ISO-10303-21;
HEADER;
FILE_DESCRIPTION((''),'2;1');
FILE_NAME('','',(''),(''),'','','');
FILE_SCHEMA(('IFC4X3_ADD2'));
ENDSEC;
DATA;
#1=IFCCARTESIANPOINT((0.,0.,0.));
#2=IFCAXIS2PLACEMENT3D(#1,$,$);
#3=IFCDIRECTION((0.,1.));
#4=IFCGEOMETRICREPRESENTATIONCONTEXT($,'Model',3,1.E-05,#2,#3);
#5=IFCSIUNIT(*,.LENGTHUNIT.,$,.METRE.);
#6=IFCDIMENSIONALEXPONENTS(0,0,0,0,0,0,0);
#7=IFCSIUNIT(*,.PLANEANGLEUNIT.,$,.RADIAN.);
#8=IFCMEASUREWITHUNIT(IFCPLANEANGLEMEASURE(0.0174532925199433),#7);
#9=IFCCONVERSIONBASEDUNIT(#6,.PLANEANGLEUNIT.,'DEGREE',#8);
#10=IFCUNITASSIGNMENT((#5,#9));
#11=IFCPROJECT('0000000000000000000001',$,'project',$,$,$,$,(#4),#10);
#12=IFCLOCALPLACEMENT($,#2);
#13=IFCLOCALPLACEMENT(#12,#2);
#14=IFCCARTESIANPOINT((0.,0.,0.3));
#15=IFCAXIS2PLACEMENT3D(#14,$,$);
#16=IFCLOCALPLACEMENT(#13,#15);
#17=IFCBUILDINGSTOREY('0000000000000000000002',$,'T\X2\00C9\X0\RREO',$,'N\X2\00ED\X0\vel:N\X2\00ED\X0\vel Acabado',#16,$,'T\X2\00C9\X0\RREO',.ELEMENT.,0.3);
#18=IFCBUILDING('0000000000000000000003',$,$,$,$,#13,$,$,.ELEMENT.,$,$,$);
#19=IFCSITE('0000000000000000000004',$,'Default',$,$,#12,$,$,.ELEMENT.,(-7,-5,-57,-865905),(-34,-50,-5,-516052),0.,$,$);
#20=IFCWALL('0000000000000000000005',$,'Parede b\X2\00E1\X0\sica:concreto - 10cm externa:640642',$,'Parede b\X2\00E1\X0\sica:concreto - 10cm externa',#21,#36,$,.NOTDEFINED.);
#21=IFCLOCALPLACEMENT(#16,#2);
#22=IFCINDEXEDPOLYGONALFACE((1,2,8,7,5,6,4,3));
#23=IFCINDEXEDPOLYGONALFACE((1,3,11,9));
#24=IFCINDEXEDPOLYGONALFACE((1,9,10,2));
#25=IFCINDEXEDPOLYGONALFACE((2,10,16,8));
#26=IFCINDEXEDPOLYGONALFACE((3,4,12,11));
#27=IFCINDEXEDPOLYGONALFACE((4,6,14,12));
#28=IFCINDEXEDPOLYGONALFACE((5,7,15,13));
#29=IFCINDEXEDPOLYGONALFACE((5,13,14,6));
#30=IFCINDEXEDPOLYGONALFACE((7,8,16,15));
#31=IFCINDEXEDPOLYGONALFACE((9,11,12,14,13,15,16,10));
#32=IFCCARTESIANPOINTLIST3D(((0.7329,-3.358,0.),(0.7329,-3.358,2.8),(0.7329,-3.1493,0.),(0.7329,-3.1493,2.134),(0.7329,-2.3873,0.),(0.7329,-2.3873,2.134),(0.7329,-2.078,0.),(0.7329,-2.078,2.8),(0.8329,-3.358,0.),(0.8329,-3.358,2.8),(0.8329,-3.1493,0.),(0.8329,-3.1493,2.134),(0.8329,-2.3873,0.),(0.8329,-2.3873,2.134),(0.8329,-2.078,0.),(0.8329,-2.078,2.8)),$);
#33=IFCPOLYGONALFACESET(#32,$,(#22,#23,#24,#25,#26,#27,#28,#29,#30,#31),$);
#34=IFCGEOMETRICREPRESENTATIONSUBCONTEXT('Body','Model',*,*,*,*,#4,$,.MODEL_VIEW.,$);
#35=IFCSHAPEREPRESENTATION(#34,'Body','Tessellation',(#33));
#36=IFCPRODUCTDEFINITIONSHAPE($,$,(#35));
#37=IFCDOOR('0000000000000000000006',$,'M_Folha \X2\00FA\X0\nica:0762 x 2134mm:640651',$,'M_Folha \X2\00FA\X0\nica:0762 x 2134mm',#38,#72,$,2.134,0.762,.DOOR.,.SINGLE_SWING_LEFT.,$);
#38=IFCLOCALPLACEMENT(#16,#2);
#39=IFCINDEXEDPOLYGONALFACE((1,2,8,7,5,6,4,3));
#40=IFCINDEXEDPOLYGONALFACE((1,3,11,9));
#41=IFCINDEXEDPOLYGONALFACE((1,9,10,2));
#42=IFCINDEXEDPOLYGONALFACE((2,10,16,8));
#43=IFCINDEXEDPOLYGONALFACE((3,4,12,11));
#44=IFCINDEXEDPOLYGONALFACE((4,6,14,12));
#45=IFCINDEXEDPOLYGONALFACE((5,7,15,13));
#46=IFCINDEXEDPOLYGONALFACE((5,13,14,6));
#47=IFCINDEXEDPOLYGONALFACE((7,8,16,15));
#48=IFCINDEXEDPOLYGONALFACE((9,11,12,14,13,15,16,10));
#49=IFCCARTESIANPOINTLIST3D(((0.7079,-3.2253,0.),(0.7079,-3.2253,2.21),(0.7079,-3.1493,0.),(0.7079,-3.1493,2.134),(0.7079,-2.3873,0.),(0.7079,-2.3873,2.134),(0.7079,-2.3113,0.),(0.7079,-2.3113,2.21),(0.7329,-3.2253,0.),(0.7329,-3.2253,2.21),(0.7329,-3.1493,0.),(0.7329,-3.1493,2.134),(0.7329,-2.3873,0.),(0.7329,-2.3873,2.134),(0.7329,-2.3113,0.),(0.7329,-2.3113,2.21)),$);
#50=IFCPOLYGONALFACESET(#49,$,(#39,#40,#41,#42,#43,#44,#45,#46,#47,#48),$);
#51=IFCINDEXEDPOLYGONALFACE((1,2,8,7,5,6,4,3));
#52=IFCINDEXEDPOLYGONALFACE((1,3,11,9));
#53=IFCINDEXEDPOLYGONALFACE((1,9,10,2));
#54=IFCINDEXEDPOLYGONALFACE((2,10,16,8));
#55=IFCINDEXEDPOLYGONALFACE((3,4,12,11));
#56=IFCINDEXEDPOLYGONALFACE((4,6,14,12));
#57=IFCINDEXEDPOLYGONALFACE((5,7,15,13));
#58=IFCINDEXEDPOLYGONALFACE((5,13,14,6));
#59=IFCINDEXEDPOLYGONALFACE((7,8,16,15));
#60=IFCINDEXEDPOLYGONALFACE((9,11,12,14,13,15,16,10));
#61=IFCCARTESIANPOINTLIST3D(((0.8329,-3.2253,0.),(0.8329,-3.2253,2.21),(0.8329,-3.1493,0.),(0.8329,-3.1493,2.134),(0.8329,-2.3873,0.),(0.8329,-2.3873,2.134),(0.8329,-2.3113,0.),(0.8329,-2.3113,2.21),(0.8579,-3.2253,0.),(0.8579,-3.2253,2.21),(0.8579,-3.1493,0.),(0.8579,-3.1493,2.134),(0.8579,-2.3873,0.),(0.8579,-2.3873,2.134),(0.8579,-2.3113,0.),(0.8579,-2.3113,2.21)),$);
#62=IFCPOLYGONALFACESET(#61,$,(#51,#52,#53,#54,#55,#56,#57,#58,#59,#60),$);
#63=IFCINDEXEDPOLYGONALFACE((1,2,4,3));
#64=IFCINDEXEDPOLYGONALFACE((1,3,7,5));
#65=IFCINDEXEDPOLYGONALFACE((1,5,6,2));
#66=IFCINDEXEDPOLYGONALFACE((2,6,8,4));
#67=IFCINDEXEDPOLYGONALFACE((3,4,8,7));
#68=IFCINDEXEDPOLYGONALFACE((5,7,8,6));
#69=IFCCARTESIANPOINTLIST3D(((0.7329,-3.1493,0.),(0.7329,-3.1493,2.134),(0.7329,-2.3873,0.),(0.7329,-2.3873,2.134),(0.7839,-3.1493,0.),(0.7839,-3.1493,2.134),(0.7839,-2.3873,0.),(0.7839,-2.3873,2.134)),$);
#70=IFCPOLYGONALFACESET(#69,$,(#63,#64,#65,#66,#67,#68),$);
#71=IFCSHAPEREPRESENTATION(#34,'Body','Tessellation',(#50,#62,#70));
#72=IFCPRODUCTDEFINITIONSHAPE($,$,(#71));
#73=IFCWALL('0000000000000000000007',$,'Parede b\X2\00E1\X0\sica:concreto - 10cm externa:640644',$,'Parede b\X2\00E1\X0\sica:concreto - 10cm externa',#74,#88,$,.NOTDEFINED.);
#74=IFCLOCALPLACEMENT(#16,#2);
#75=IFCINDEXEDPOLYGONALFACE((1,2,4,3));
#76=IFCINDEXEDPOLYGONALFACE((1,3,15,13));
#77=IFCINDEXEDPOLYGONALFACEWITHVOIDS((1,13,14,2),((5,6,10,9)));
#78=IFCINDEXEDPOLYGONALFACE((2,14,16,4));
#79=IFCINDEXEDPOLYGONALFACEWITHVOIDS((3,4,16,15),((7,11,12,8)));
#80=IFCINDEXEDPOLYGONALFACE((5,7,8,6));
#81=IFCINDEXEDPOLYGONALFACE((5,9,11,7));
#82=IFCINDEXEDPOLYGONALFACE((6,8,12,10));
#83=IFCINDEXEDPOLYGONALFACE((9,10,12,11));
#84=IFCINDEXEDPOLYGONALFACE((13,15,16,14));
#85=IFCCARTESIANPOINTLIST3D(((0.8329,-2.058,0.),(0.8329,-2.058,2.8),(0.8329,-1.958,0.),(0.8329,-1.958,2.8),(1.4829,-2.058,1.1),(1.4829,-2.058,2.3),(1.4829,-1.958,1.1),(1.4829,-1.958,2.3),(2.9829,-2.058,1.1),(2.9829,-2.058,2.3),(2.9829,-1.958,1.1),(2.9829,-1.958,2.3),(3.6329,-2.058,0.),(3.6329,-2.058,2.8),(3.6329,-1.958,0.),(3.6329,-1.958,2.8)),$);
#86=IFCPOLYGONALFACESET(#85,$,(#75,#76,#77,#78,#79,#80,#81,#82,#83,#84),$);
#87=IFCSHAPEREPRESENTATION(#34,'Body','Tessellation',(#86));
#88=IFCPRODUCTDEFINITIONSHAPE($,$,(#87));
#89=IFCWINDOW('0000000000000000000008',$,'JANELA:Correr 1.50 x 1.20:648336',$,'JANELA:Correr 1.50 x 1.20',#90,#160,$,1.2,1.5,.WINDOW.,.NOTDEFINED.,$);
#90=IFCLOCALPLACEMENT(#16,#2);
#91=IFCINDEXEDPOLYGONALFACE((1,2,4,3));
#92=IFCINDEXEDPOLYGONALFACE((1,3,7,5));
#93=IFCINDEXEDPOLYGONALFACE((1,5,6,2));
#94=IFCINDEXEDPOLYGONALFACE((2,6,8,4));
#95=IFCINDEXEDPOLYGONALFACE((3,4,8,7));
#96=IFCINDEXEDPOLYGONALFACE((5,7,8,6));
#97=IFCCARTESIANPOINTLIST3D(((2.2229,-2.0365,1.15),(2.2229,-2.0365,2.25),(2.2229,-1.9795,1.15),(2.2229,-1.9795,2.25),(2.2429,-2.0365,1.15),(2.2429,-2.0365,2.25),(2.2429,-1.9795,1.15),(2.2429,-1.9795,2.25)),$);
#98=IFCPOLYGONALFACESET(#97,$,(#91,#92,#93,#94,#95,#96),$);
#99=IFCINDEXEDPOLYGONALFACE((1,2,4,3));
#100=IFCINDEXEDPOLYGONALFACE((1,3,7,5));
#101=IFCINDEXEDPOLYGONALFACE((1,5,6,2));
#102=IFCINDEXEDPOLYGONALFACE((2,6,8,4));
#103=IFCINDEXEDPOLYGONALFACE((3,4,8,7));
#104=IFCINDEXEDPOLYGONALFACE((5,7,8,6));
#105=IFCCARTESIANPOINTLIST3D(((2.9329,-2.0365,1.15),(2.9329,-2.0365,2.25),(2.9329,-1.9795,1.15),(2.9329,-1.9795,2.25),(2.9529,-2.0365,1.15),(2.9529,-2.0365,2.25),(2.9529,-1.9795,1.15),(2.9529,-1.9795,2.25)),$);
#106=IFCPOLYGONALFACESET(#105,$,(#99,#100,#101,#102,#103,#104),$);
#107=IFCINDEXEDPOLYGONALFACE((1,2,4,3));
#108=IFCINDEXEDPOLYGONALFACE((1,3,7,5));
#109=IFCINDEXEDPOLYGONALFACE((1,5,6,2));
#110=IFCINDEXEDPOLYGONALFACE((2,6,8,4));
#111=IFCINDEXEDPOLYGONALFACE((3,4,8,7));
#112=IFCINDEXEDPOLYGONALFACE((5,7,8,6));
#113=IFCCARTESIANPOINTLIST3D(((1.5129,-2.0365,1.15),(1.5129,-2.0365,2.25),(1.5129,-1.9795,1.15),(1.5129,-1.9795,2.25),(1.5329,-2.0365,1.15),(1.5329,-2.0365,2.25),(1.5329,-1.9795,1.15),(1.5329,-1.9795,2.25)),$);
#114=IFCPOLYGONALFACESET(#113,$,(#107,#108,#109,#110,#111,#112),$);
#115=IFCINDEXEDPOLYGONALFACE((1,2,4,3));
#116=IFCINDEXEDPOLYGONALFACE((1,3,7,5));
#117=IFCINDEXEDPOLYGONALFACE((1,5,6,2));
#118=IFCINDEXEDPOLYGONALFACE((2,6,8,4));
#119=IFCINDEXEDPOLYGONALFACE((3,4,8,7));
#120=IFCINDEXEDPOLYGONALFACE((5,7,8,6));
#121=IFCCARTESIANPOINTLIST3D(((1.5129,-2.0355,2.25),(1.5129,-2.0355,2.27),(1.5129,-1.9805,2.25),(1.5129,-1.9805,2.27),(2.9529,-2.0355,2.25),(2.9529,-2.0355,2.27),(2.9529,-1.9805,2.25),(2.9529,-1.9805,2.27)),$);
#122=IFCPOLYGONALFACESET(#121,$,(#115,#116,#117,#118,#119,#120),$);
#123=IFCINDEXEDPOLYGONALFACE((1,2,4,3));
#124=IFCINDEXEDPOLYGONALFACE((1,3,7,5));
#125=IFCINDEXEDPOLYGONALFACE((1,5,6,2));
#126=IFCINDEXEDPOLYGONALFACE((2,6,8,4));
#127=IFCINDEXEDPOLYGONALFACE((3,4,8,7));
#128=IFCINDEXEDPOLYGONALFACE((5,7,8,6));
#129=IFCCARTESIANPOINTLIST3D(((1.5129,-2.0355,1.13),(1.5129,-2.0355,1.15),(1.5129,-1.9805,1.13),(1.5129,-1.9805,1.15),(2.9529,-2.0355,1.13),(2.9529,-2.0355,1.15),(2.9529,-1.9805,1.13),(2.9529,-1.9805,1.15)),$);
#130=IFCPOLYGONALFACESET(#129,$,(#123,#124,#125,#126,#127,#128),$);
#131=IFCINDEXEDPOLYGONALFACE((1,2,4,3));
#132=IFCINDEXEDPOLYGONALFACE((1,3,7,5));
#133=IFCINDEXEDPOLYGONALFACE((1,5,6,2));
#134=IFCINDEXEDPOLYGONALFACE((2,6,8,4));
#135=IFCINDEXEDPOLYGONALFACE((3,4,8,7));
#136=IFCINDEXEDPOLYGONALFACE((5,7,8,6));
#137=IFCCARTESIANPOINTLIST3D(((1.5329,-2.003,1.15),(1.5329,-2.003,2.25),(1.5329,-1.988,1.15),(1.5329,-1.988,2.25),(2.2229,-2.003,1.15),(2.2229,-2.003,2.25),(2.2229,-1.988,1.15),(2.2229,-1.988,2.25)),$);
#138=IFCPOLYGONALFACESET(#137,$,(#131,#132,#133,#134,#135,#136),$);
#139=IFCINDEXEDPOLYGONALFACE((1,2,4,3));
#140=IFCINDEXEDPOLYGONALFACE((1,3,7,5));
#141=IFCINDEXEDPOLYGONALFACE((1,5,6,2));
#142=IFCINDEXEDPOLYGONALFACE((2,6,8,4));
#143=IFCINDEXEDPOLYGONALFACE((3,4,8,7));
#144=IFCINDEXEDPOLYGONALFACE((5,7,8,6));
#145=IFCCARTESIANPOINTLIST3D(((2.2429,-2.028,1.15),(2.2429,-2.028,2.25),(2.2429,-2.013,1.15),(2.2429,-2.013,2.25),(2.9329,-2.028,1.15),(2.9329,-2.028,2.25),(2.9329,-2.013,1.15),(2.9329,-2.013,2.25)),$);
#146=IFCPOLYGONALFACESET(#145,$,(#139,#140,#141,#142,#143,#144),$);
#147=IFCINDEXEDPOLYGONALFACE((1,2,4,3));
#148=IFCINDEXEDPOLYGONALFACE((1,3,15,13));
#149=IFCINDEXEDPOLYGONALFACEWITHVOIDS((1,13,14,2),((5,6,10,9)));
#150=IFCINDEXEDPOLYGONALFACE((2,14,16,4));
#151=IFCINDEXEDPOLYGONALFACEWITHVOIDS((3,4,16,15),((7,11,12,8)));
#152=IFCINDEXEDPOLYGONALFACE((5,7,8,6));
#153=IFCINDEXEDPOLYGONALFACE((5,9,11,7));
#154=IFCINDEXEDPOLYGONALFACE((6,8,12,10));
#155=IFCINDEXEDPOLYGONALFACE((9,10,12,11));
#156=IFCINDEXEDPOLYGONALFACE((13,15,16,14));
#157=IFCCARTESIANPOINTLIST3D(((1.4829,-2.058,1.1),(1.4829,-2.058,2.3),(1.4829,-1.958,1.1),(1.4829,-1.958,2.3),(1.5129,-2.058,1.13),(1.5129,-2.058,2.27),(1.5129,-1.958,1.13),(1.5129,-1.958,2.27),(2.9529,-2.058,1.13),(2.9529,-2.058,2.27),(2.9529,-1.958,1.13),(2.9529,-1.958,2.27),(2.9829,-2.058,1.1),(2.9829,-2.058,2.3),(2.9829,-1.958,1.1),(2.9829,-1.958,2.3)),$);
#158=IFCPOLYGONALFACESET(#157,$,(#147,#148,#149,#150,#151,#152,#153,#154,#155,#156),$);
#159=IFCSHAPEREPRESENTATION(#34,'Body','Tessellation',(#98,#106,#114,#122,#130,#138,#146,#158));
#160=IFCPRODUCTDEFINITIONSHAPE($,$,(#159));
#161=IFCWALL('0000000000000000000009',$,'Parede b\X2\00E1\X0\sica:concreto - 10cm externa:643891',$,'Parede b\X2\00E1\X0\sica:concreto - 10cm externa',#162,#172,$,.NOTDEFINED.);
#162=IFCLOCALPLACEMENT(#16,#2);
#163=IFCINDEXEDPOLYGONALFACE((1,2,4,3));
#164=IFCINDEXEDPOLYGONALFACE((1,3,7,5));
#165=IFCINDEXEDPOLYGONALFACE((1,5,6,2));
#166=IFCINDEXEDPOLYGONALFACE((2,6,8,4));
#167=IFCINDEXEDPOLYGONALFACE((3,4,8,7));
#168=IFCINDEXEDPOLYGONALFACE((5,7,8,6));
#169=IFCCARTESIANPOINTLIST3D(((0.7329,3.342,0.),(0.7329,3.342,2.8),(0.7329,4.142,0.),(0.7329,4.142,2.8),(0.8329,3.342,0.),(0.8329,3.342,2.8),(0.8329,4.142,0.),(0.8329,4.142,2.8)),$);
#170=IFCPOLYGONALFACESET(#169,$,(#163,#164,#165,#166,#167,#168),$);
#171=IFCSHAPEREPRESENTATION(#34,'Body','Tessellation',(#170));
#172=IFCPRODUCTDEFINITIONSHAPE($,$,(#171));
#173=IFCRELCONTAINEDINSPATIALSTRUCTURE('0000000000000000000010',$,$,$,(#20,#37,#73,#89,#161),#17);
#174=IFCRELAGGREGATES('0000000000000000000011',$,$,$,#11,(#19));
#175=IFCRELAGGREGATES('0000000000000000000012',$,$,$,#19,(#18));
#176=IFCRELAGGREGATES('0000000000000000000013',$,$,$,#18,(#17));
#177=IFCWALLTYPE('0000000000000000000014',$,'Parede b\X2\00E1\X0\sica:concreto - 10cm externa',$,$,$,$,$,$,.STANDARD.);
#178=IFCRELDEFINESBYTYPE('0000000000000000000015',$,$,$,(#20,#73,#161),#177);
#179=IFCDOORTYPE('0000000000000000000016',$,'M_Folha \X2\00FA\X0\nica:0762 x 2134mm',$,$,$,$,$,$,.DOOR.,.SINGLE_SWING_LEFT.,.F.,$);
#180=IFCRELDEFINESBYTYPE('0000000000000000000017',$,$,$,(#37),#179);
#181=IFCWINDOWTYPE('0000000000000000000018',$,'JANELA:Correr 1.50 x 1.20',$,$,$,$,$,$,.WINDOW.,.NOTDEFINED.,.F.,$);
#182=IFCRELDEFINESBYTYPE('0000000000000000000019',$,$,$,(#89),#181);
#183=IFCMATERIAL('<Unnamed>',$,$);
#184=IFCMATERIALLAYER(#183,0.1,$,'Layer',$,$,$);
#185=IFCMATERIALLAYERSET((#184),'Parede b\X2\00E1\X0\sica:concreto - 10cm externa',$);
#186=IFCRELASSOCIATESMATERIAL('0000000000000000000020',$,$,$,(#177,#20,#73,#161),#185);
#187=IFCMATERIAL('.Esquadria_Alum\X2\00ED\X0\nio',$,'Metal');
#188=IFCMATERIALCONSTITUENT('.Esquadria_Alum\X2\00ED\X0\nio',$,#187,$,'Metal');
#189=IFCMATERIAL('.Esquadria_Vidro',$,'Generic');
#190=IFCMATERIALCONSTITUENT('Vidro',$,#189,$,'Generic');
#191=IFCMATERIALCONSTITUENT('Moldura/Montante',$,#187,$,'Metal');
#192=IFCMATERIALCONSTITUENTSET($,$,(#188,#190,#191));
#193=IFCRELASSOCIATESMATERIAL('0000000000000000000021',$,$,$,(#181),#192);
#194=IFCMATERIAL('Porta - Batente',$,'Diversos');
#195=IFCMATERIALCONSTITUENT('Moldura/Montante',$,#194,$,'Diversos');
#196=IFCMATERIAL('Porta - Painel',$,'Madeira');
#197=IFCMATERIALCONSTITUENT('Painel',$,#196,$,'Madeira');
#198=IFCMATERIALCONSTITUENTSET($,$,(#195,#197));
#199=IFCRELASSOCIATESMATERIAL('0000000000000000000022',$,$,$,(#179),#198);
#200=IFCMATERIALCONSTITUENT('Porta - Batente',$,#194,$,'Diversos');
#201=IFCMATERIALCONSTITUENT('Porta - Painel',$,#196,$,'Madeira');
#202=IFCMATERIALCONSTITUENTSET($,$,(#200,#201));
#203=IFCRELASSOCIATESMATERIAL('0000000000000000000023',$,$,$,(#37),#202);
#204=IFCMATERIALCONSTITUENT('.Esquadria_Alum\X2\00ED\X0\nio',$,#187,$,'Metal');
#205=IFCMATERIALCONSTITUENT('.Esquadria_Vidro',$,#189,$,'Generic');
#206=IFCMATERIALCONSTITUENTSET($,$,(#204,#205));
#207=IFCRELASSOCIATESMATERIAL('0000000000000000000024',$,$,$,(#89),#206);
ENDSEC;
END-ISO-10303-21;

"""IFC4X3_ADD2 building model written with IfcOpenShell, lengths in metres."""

from ifc_helpers import new_model, entity, si_unit, converted_unit, direction, frame, frame_2d, origin, origin_2d_with_axis, place, context, subcontext, project, spatial, polyline, rectangle, outline, extrude, source, transform, mapped, material, layer, layer_set, constituent, constituent_set, type_object, type_shapes, element, fill, save


model = new_model("IFC4X3_ADD2")

# Units and contexts
model_context = context("Model", 3, precision=1e-05, world=origin(), true_north=direction((0.0, 1.0)))
body_context = subcontext(model_context, "Body", "Model", "MODEL_VIEW")
ifc_project = project(units=[si_unit("LENGTHUNIT", "METRE"), converted_unit("PLANEANGLEUNIT", "DEGREE", entity("IfcPlaneAngleMeasure", 0.0174532925199433), si_unit("PLANEANGLEUNIT", "RADIAN"), dimensions=[0, 0, 0, 0, 0, 0, 0])], contexts=[model_context])

# Site, building, storey
site_placement = place(None, origin())
site = spatial("IfcSite", under=ifc_project, at=site_placement, Name="Default", CompositionType="ELEMENT", RefLatitude=(-7, -5, -57, -865905), RefLongitude=(-34, -50, -5, -516052), RefElevation=0.0)
building_placement = place(site_placement, origin())
building = spatial("IfcBuilding", under=site, at=building_placement, CompositionType="ELEMENT")
storey_placement = place(building_placement, frame((0.0, 0.0, 0.3)))
storey = spatial("IfcBuildingStorey", under=building, at=storey_placement, Name="TÉRREO", ObjectType="Nível:Nível Acabado", LongName="TÉRREO", CompositionType="ELEMENT", Elevation=0.3)

# Shared definitions
ifc_material_1 = material(Name="<Unnamed>")
ifc_layer_1 = layer(ifc_material_1, 0.1, Name="Layer")
ifc_layer_set_1 = layer_set([ifc_layer_1], Name="Parede básica:concreto - 10cm externa")
wall_type_1 = type_object("IfcWallType", Name="Parede básica:concreto - 10cm externa", PredefinedType="STANDARD", material=ifc_layer_set_1)
ifc_material_2 = material(Name=".Esquadria_Alumínio", Category="Metal")
ifc_material_3 = material(Name=".Esquadria_Vidro", Category="Generic")
ifc_constituent_1 = constituent(ifc_material_2, Name=".Esquadria_Alumínio", Category="Metal")
ifc_constituent_2 = constituent(ifc_material_3, Name="Vidro", Category="Generic")
ifc_constituent_3 = constituent(ifc_material_2, Name="Moldura/Montante", Category="Metal")
ifc_constituent_set_1 = constituent_set(constituents=[ifc_constituent_1, ifc_constituent_2, ifc_constituent_3])
window_type_1 = type_object("IfcWindowType", Name="JANELA:Correr 1.50 x 1.20", ParameterTakesPrecedence=False, PartitioningType="NOTDEFINED", PredefinedType="WINDOW", material=ifc_constituent_set_1)
shared_shape_1 = source(origin(), body_context, "Body", "SweptSolid", [
    extrude(rectangle(XDim=0.02, YDim=0.057, at=origin_2d_with_axis()), frame((0.75, 0.05, 0.05), z_axis=(0.0, 0.0, 1.0), x_axis=(-1.0, 0.0, 0.0)), (0.0, 0.0, 1.0), 1.1),
    extrude(rectangle(XDim=0.02, YDim=0.057, at=origin_2d_with_axis()), frame((0.04, 0.05, 0.05), z_axis=(0.0, 0.0, 1.0), x_axis=(-1.0, 0.0, 0.0)), (0.0, 0.0, 1.0), 1.1),
    extrude(rectangle(XDim=0.02, YDim=0.057, at=origin_2d_with_axis()), frame((1.46, 0.05, 0.05), z_axis=(0.0, 0.0, 1.0), x_axis=(-1.0, 0.0, 0.0)), (0.0, 0.0, 1.0), 1.1),
    extrude(rectangle(XDim=1.44, YDim=0.055, at=origin_2d_with_axis()), frame((0.75, 0.05, 1.15), z_axis=(0.0, 0.0, 1.0), x_axis=(-1.0, 0.0, 0.0)), (0.0, 0.0, 1.0), 0.02),
    extrude(rectangle(XDim=1.44, YDim=0.055, at=origin_2d_with_axis()), frame((0.75, 0.05, 0.03), z_axis=(0.0, 0.0, 1.0), x_axis=(-1.0, 0.0, 0.0)), (0.0, 0.0, 1.0), 0.02),
    extrude(rectangle(XDim=0.015, YDim=0.69, at=frame_2d((0.0, 0.0), x_axis=(1.0, 0.0))), frame((1.105, 0.0375, 0.05), z_axis=(0.0, 0.0, 1.0), x_axis=(0.0, 1.0, 0.0)), (0.0, 0.0, 1.0), 1.1),
    extrude(rectangle(XDim=0.015, YDim=0.69, at=origin_2d_with_axis()), frame((0.395, 0.0625, 0.05), z_axis=(0.0, 0.0, 1.0), x_axis=(0.0, 1.0, 0.0)), (0.0, 0.0, 1.0), 1.1),
    extrude(outline(polyline([(-0.75, -0.6), (0.75, -0.6), (0.75, 0.6), (-0.75, 0.6), (-0.75, -0.6)]), holes=[polyline([(0.72, -0.57), (-0.72, -0.57), (-0.72, 0.57), (0.72, 0.57), (0.72, -0.57)])]), frame((0.75, 0.0, 0.6), z_axis=(0.0, 1.0, 0.0), x_axis=(1.0, 0.0, 0.0)), (0.0, 0.0, 1.0), 0.1),
])
type_shapes(window_type_1, [shared_shape_1])

# Wall, opening, door
ifc_material_4 = material(Name="Porta - Batente", Category="Diversos")
ifc_material_5 = material(Name="Porta - Painel", Category="Madeira")
wall_1_placement = place(storey_placement, frame((0.7829, -3.358, 0.0), z_axis=(0.0, 0.0, 1.0), x_axis=(0.0, 1.0, 0.0)))
wall_1 = element("IfcWall", 1, at=wall_1_placement, inside=storey, type_object=wall_type_1, material=ifc_layer_set_1, Name="Parede básica:concreto - 10cm externa:640642", ObjectType="Parede básica:concreto - 10cm externa", PredefinedType="NOTDEFINED", context=body_context, shape_type="SweptSolid", body=[
    extrude(rectangle(XDim=1.28, YDim=0.1, at=frame_2d((0.64, 0.0), x_axis=(1.0, 0.0))), origin(), (0.0, 0.0, 1.0), 2.8),
])
opening_1_placement = place(wall_1_placement, frame((0.2087, -0.05, 0.0)))
opening_1 = element("IfcOpeningElement", 2, at=opening_1_placement, cuts=wall_1, PredefinedType="OPENING", context=body_context, shape_type="SweptSolid", body=[
    extrude(rectangle(XDim=0.762, YDim=2.134, at=frame_2d((1.067, 0.381), x_axis=(0.0, -1.0))), frame((0.0, 0.0, 0.0), z_axis=(0.0, 1.0, 0.0), x_axis=(0.0, 0.0, 1.0)), (0.0, 0.0, 1.0), 0.1),
])
ifc_constituent_4 = constituent(ifc_material_4, Name="Porta - Batente", Category="Diversos")
ifc_constituent_5 = constituent(ifc_material_5, Name="Porta - Painel", Category="Madeira")
ifc_constituent_set_2 = constituent_set(constituents=[ifc_constituent_4, ifc_constituent_5])
ifc_constituent_6 = constituent(ifc_material_4, Name="Moldura/Montante", Category="Diversos")
ifc_constituent_7 = constituent(ifc_material_5, Name="Painel", Category="Madeira")
ifc_constituent_set_3 = constituent_set(constituents=[ifc_constituent_6, ifc_constituent_7])
door_type_1 = type_object("IfcDoorType", Name="M_Folha única:0762 x 2134mm", OperationType="SINGLE_SWING_LEFT", ParameterTakesPrecedence=False, PredefinedType="DOOR", material=ifc_constituent_set_3)
shared_shape_2 = source(origin(), body_context, "Body", "SweptSolid", [
    extrude(outline(polyline([(-0.457, -1.124), (0.457, -1.124), (0.457, 1.086), (0.381, 1.086), (0.381, -1.048), (-0.381, -1.048), (-0.381, 1.086), (-0.457, 1.086), (-0.457, -1.124)])), frame((0.381, 0.125, 1.086), z_axis=(0.0, -1.0, 0.0), x_axis=(-1.0, 0.0, 0.0)), (0.0, 0.0, 1.0), 0.025),
    extrude(outline(polyline([(-1.124, -0.457), (1.086, -0.457), (1.086, -0.381), (-1.048, -0.381), (-1.048, 0.381), (1.086, 0.381), (1.086, 0.457), (-1.124, 0.457), (-1.124, -0.457)])), frame((0.381, 0.0, 1.086), z_axis=(0.0, -1.0, 0.0), x_axis=(0.0, 0.0, -1.0)), (0.0, 0.0, 1.0), 0.025),
    extrude(rectangle(XDim=0.762, YDim=0.051, at=origin_2d_with_axis()), frame((0.381, 0.0745, 0.0)), (0.0, 0.0, 1.0), 2.134),
])
type_shapes(door_type_1, [shared_shape_2])
door_1_placement = place(opening_1_placement, origin())
door_1 = element("IfcDoor", 3, at=door_1_placement, inside=storey, type_object=door_type_1, material=ifc_constituent_set_2, Name="M_Folha única:0762 x 2134mm:640651", ObjectType="M_Folha única:0762 x 2134mm", OperationType="SINGLE_SWING_LEFT", OverallHeight=2.134, OverallWidth=0.762, PredefinedType="DOOR", context=body_context, shape_type="MappedRepresentation", body=[
    mapped(shared_shape_2, transform((0.0, 0.0, 0.0), scale=1.0)),
])
fill(opening_1, door_1)

# Wall, opening, window
wall_2_placement = place(storey_placement, frame((0.8329, -2.008, 0.0)))
wall_2 = element("IfcWall", 4, at=wall_2_placement, inside=storey, type_object=wall_type_1, material=ifc_layer_set_1, Name="Parede básica:concreto - 10cm externa:640644", ObjectType="Parede básica:concreto - 10cm externa", PredefinedType="NOTDEFINED", context=body_context, shape_type="SweptSolid", body=[
    extrude(rectangle(XDim=2.8, YDim=0.1, at=frame_2d((1.4, 0.0), x_axis=(-1.0, 0.0))), origin(), (0.0, 0.0, 1.0), 2.8),
])
opening_2_placement = place(wall_2_placement, frame((2.15, 0.05, 1.1)))
opening_2 = element("IfcOpeningElement", 5, at=opening_2_placement, cuts=wall_2, PredefinedType="OPENING", context=body_context, shape_type="SweptSolid", body=[
    extrude(rectangle(XDim=1.2, YDim=1.5, at=frame_2d((0.6, 0.75), x_axis=(1.0, 0.0))), frame((0.0, 0.0, 0.0), z_axis=(0.0, -1.0, 0.0), x_axis=(0.0, 0.0, 1.0)), (0.0, 0.0, 1.0), 0.1),
])
ifc_constituent_8 = constituent(ifc_material_2, Name=".Esquadria_Alumínio", Category="Metal")
ifc_constituent_9 = constituent(ifc_material_3, Name=".Esquadria_Vidro", Category="Generic")
ifc_constituent_set_4 = constituent_set(constituents=[ifc_constituent_8, ifc_constituent_9])
window_1_placement = place(opening_2_placement, frame((0.0, 0.0, 0.0), z_axis=(0.0, 0.0, 1.0), x_axis=(-1.0, 0.0, 0.0)))
window_1 = element("IfcWindow", 6, at=window_1_placement, inside=storey, type_object=window_type_1, material=ifc_constituent_set_4, Name="JANELA:Correr 1.50 x 1.20:648336", ObjectType="JANELA:Correr 1.50 x 1.20", OverallHeight=1.2, OverallWidth=1.5, PartitioningType="NOTDEFINED", PredefinedType="WINDOW", context=body_context, shape_type="MappedRepresentation", body=[
    mapped(shared_shape_1, transform((0.0, 0.0, 0.0), scale=1.0)),
])
fill(opening_2, window_1)

# Wall
wall_3_placement = place(storey_placement, frame((0.7829, 3.342, 0.0), z_axis=(0.0, 0.0, 1.0), x_axis=(0.0, 1.0, 0.0)))
element("IfcWall", 7, at=wall_3_placement, inside=storey, type_object=wall_type_1, material=ifc_layer_set_1, Name="Parede básica:concreto - 10cm externa:643891", ObjectType="Parede básica:concreto - 10cm externa", PredefinedType="NOTDEFINED", context=body_context, shape_type="SweptSolid", body=[
    extrude(rectangle(XDim=0.8, YDim=0.1, at=frame_2d((0.4, 0.0), x_axis=(-1.0, 0.0))), origin(), (0.0, 0.0, 1.0), 2.8),
])

save(model, "model.ifc")
